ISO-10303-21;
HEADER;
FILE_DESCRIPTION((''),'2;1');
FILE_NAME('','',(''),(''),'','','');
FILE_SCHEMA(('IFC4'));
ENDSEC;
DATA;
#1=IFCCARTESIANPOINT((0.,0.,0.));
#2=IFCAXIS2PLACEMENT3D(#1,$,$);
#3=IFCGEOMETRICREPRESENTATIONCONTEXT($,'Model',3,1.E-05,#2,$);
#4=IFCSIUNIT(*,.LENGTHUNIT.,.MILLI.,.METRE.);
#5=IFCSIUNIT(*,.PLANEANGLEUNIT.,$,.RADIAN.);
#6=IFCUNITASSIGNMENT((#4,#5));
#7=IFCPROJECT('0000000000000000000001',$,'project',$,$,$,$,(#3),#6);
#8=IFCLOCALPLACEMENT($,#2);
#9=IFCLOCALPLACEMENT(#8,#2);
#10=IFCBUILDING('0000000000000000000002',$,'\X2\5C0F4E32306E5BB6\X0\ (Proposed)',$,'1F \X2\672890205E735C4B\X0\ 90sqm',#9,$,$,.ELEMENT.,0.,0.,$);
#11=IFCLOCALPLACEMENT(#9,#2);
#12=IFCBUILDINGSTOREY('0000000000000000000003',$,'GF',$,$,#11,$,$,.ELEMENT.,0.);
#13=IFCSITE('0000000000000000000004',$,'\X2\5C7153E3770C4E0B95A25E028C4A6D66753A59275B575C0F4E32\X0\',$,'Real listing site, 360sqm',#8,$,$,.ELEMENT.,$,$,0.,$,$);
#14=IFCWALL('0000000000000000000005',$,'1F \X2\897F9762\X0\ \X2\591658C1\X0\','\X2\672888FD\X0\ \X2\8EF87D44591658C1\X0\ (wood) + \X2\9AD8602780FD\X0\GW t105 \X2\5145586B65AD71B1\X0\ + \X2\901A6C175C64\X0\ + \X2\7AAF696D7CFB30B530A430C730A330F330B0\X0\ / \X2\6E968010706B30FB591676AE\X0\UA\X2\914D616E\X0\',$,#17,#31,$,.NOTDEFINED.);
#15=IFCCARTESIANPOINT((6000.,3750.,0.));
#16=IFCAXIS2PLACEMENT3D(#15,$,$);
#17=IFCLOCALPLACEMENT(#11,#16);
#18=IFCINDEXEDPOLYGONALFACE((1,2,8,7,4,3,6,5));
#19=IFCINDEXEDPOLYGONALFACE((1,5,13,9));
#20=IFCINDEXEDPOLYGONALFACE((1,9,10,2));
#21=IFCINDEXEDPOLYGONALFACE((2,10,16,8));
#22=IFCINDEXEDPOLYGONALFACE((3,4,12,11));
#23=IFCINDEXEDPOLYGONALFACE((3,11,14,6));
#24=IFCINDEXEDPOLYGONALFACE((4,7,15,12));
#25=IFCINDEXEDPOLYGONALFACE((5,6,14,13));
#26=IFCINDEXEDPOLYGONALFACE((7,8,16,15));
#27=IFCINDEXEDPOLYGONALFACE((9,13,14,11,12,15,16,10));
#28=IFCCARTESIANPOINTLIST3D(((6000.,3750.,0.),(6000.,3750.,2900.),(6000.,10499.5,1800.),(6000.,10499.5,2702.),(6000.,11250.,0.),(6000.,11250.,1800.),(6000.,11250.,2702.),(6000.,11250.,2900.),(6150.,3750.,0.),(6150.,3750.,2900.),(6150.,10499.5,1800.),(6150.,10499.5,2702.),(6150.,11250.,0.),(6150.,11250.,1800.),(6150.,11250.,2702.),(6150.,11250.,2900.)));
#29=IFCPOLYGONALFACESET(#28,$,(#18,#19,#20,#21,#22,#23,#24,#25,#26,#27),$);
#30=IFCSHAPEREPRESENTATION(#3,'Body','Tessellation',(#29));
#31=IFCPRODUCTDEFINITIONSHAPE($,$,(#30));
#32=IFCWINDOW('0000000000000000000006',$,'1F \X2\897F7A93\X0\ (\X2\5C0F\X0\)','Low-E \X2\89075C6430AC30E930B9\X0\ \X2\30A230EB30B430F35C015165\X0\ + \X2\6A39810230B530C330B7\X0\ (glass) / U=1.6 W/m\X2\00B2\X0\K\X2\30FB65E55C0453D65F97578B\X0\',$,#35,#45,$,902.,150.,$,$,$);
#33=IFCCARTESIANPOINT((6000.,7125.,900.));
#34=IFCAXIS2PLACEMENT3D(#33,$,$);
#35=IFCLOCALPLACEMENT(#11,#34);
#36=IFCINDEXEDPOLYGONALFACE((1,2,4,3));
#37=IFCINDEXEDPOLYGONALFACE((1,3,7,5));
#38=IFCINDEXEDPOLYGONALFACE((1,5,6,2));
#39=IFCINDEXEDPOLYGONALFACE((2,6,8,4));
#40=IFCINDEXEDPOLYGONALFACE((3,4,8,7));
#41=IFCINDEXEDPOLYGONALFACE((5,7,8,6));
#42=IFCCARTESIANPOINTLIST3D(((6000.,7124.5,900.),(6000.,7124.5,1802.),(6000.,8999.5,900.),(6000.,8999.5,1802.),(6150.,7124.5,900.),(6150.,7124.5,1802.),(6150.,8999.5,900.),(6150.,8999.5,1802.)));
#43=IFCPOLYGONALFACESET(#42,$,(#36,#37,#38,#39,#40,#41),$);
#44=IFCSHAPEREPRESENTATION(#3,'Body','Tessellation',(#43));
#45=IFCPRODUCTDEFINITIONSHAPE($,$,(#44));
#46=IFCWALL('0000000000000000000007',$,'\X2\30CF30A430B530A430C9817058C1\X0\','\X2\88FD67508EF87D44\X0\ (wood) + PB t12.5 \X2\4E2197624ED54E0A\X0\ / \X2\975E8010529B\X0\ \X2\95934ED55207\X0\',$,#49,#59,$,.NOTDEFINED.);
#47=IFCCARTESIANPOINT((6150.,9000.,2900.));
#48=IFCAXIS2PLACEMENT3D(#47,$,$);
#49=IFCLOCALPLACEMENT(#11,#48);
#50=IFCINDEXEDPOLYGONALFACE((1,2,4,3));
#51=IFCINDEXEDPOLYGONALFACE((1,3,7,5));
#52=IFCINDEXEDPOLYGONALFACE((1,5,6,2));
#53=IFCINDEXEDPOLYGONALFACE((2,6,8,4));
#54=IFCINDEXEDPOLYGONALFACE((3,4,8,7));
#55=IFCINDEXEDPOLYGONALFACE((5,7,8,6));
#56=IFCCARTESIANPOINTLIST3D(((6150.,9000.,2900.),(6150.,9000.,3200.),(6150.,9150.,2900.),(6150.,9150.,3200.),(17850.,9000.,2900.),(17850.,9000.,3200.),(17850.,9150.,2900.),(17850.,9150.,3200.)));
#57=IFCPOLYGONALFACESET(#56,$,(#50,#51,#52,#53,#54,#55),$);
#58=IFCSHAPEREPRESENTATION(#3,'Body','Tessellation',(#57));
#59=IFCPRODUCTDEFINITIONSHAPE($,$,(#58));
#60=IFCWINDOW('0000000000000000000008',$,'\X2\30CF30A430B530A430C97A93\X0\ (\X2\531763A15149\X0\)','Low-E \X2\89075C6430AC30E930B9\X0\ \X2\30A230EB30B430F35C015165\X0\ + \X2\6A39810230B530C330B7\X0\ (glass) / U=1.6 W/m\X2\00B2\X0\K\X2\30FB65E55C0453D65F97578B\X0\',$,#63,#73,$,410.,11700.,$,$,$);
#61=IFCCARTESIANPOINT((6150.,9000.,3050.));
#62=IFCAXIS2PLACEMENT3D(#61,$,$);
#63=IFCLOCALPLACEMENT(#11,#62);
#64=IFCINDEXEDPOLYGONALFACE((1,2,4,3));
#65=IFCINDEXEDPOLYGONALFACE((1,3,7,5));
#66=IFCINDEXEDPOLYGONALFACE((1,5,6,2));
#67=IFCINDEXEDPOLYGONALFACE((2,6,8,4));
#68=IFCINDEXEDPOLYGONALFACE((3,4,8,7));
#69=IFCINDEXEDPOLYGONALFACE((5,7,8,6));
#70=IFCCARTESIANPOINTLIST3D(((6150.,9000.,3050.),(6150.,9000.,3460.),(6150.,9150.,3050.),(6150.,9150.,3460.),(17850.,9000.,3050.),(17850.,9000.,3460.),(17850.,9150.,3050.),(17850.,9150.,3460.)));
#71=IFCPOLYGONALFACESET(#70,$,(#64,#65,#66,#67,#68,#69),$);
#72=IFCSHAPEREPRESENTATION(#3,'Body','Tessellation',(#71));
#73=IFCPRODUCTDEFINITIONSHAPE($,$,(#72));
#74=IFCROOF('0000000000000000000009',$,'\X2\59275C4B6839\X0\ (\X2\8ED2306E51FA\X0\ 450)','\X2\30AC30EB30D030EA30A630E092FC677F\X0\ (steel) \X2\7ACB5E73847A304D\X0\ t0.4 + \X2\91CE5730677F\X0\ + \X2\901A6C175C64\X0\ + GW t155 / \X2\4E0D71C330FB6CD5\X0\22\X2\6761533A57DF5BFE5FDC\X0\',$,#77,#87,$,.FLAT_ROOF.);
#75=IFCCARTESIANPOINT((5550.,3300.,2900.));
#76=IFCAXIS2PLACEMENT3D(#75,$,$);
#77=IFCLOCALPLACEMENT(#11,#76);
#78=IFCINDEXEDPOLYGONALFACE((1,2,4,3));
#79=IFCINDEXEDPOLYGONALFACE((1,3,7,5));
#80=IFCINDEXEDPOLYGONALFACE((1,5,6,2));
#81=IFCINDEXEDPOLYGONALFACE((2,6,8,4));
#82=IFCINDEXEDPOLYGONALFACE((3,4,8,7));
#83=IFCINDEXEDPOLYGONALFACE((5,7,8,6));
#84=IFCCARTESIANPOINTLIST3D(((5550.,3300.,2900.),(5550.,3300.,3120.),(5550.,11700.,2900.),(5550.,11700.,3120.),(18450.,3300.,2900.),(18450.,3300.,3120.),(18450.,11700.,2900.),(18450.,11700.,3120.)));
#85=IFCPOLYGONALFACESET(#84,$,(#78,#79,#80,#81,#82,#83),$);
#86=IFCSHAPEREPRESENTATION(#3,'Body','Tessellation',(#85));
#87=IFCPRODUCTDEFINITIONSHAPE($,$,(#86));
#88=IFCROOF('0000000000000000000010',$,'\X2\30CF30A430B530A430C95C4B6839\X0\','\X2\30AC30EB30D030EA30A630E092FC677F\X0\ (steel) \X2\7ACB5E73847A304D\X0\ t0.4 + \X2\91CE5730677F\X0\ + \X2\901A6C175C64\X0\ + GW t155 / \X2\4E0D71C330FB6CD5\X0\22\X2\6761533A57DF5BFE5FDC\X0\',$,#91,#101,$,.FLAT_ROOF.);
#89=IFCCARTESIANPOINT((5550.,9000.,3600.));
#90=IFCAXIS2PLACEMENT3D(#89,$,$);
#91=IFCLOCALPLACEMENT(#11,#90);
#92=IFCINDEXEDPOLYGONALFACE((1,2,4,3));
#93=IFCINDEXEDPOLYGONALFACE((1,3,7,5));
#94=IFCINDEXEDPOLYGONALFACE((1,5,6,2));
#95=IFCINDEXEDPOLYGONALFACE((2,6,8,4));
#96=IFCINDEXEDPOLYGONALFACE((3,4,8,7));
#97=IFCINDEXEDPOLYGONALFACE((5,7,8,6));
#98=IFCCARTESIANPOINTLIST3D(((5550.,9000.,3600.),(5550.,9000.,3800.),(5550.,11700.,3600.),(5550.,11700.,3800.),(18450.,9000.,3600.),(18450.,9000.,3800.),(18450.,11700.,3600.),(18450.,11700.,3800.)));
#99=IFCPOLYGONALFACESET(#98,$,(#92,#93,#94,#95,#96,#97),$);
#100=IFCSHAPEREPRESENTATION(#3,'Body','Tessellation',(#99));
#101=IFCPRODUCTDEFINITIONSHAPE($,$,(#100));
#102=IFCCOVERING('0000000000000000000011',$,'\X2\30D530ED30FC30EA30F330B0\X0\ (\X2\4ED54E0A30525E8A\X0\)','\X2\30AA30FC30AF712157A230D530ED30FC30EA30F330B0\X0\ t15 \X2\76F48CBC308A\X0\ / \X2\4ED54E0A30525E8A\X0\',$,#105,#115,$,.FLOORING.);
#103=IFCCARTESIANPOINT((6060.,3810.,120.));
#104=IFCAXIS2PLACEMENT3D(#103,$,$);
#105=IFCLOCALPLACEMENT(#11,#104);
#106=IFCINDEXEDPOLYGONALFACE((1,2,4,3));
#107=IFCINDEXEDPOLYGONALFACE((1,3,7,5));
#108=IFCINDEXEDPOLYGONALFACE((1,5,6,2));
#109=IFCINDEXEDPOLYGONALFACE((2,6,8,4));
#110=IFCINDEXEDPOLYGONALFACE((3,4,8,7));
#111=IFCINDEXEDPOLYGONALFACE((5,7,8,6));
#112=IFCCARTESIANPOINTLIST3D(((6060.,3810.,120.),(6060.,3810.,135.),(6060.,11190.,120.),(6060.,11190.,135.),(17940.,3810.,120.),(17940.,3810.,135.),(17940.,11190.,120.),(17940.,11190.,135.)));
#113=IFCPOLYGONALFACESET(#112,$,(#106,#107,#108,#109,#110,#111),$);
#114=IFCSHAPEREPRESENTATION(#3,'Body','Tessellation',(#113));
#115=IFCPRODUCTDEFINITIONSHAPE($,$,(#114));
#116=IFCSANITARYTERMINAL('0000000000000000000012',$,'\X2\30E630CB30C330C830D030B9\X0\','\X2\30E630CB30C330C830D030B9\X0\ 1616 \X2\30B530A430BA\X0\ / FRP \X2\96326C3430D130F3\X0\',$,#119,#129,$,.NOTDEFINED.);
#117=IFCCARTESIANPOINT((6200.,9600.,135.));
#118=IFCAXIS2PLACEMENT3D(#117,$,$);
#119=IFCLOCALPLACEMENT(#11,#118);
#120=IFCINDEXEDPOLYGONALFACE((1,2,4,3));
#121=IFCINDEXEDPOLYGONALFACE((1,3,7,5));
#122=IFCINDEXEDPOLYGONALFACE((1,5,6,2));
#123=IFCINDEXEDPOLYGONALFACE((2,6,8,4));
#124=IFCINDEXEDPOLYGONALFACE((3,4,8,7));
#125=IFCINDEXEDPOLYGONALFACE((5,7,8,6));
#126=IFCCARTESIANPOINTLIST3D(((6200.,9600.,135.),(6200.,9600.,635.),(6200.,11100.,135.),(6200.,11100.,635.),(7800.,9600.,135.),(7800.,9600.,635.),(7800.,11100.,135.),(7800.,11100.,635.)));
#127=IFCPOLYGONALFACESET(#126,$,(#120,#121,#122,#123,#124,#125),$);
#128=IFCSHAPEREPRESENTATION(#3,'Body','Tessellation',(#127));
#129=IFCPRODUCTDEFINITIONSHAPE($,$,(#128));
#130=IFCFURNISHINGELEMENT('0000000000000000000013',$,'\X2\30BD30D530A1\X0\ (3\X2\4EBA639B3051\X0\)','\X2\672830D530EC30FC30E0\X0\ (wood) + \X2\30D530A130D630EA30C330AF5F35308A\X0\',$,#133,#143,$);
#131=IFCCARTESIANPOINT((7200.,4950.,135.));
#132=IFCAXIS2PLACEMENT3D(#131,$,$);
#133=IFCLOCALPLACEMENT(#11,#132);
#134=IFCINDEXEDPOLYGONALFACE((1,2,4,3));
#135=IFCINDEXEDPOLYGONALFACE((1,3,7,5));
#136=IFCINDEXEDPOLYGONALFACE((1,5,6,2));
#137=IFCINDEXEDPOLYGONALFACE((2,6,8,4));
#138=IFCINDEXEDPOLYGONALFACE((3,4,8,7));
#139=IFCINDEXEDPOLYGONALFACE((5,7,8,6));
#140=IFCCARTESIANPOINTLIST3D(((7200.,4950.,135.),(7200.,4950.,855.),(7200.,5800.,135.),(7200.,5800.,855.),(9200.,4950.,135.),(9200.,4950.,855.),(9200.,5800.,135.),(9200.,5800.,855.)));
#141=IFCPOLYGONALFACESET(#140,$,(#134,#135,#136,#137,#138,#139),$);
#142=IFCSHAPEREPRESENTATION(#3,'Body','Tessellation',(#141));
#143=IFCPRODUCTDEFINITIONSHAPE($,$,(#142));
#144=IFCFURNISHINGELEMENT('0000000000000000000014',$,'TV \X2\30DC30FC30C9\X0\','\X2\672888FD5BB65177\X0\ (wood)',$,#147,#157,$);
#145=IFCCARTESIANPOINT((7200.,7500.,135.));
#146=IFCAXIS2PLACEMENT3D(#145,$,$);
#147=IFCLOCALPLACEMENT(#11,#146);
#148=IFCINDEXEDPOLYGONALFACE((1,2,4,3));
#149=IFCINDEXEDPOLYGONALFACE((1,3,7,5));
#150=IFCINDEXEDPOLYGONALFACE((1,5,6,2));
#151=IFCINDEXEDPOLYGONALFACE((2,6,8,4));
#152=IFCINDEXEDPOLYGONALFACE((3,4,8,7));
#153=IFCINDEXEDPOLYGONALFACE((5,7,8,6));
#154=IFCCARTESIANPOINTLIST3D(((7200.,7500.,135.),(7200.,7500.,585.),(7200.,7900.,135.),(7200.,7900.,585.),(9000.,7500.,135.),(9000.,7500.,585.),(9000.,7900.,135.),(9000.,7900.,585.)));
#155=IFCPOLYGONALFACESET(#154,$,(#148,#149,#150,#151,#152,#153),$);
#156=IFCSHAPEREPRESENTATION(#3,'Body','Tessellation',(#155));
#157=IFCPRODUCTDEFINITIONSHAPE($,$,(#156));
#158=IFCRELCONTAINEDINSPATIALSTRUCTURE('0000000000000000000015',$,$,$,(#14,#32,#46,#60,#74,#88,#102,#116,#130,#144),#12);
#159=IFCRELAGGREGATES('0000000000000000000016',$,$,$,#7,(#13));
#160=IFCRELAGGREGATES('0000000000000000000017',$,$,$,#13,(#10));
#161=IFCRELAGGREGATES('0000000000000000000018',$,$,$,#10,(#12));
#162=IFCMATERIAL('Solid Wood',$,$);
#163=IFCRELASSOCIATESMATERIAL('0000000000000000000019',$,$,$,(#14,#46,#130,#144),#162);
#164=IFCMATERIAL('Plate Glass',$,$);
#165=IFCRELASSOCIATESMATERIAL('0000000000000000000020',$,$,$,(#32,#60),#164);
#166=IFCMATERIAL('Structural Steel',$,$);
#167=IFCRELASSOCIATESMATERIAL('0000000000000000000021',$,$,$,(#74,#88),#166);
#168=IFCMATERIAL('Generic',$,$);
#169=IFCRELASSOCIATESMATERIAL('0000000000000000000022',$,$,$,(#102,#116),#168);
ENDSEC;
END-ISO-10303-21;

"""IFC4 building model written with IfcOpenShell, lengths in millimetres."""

from ifc_helpers import new_model, si_unit, frame, frame_2d, origin, place, context, project, spatial, rectangle, extrude, material, element, fill, save


model = new_model("IFC4")

# Units and contexts
model_context = context("Model", 3, precision=1e-05, world=origin())
ifc_project = project(units=[si_unit("LENGTHUNIT", "METRE", prefix="MILLI"), si_unit("PLANEANGLEUNIT", "RADIAN")], contexts=[model_context])

# Site, building, storey
site_placement = place(None, origin())
site = spatial("IfcSite", under=ifc_project, at=site_placement, Name="山口県下関市豊浦町大字小串", ObjectType="Real listing site, 360sqm", CompositionType="ELEMENT", RefElevation=0.0)
building_placement = place(site_placement, origin())
building = spatial("IfcBuilding", under=site, at=building_placement, Name="小串の家 (Proposed)", ObjectType="1F 木造平屋 90sqm", CompositionType="ELEMENT", ElevationOfRefHeight=0.0, ElevationOfTerrain=0.0)
storey_placement = place(building_placement, origin())
storey = spatial("IfcBuildingStorey", under=building, at=storey_placement, Name="GF", CompositionType="ELEMENT", Elevation=0.0)

# Shared definitions
ifc_material_1 = material(Name="Solid Wood")

# Shared definitions
ifc_material_2 = material(Name="Plate Glass")

# Wall, opening, window
wall_1_placement = place(storey_placement, frame((6000.0, 3750.0, 0.0)))
wall_1 = element("IfcWall", 1, at=wall_1_placement, inside=storey, material=ifc_material_1, Name="1F 西面 外壁", Description="木製 軸組外壁 (wood) + 高性能GW t105 充填断熱 + 通気層 + 窯業系サイディング / 準耐火・外皮UA配慮", PredefinedType="NOTDEFINED", context=model_context, shape_type="SweptSolid", body=[
    extrude(rectangle(XDim=150.0, YDim=7500.0, at=frame_2d((75.0, 3750.0))), frame((6000.0, 3750.0, 0.0)), (0.0, 0.0, 1.0), 2900.0),
])
opening_1_placement = place(storey_placement, frame((6000.0, 7125.0, 900.0)))
opening_1 = element("IfcOpeningElement", 2, at=opening_1_placement, cuts=wall_1, PredefinedType="NOTDEFINED", context=model_context, shape_type="SweptSolid", body=[
    extrude(rectangle(XDim=150.0, YDim=1875.0, at=frame_2d((75.0, 937.0))), frame((6000.0, 7125.0, 900.0)), (0.0, 0.0, 1.0), 902.0),
])
window_1_placement = place(storey_placement, frame((6000.0, 7125.0, 900.0)))
window_1 = element("IfcWindow", 3, at=window_1_placement, inside=storey, material=ifc_material_2, Name="1F 西窓 (小)", Description="Low-E 複層ガラス アルゴン封入 + 樹脂サッシ (glass) / U=1.6 W/m²K・日射取得型", OverallHeight=902.0, OverallWidth=150.0, context=model_context, shape_type="SweptSolid", body=[
    extrude(rectangle(XDim=150.0, YDim=1875.0, at=frame_2d((75.0, 937.0))), frame((6000.0, 7125.0, 900.0)), (0.0, 0.0, 1.0), 902.0),
])
fill(opening_1, window_1)

# Wall, opening, window
wall_2_placement = place(storey_placement, frame((6150.0, 9000.0, 2900.0)))
wall_2 = element("IfcWall", 4, at=wall_2_placement, inside=storey, material=ifc_material_1, Name="ハイサイド腰壁", Description="製材軸組 (wood) + PB t12.5 両面仕上 / 非耐力 間仕切", PredefinedType="NOTDEFINED", context=model_context, shape_type="SweptSolid", body=[
    extrude(rectangle(XDim=11700.0, YDim=150.0, at=frame_2d((5850.0, 75.0))), frame((6150.0, 9000.0, 2900.0)), (0.0, 0.0, 1.0), 700.0),
])
opening_2_placement = place(storey_placement, frame((6150.0, 9000.0, 3050.0)))
opening_2 = element("IfcOpeningElement", 5, at=opening_2_placement, cuts=wall_2, PredefinedType="NOTDEFINED", context=model_context, shape_type="SweptSolid", body=[
    extrude(rectangle(XDim=11700.0, YDim=150.0, at=frame_2d((5850.0, 75.0))), frame((6150.0, 9000.0, 3050.0)), (0.0, 0.0, 1.0), 410.0),
])
window_2_placement = place(storey_placement, frame((6150.0, 9000.0, 3050.0)))
window_2 = element("IfcWindow", 6, at=window_2_placement, inside=storey, material=ifc_material_2, Name="ハイサイド窓 (北採光)", Description="Low-E 複層ガラス アルゴン封入 + 樹脂サッシ (glass) / U=1.6 W/m²K・日射取得型", OverallHeight=410.0, OverallWidth=11700.0, context=model_context, shape_type="SweptSolid", body=[
    extrude(rectangle(XDim=11700.0, YDim=150.0, at=frame_2d((5850.0, 75.0))), frame((6150.0, 9000.0, 3050.0)), (0.0, 0.0, 1.0), 410.0),
])
fill(opening_2, window_2)

# Roofs
ifc_material_3 = material(Name="Structural Steel")
roof_1_placement = place(storey_placement, frame((5550.0, 3300.0, 2900.0)))
element("IfcRoof", 7, at=roof_1_placement, inside=storey, material=ifc_material_3, Name="大屋根 (軒の出 450)", Description="ガルバリウム鋼板 (steel) 立平葺き t0.4 + 野地板 + 通気層 + GW t155 / 不燃・法22条区域対応", PredefinedType="FLAT_ROOF", context=model_context, shape_type="SweptSolid", body=[
    extrude(rectangle(XDim=12900.0, YDim=8400.0, at=frame_2d((6450.0, 4200.0))), frame((5550.0, 3300.0, 2900.0)), (0.0, 0.0, 1.0), 220.0),
])
roof_2_placement = place(storey_placement, frame((5550.0, 9000.0, 3600.0)))
element("IfcRoof", 8, at=roof_2_placement, inside=storey, material=ifc_material_3, Name="ハイサイド屋根", Description="ガルバリウム鋼板 (steel) 立平葺き t0.4 + 野地板 + 通気層 + GW t155 / 不燃・法22条区域対応", PredefinedType="FLAT_ROOF", context=model_context, shape_type="SweptSolid", body=[
    extrude(rectangle(XDim=12900.0, YDim=2700.0, at=frame_2d((6450.0, 1350.0))), frame((5550.0, 9000.0, 3600.0)), (0.0, 0.0, 1.0), 200.0),
])

# Covering
ifc_material_4 = material(Name="Generic")
covering_placement = place(storey_placement, frame((6060.0, 3810.0, 120.0)))
element("IfcCovering", 9, at=covering_placement, inside=storey, material=ifc_material_4, Name="フローリング (仕上げ床)", Description="オーク無垢フローリング t15 直貼り / 仕上げ床", PredefinedType="FLOORING", context=model_context, shape_type="SweptSolid", body=[
    extrude(rectangle(XDim=11880.0, YDim=7380.0, at=frame_2d((5940.0, 3690.0))), frame((6060.0, 3810.0, 120.0)), (0.0, 0.0, 1.0), 15.0),
])

# Sanitary terminal
sanitary_terminal_placement = place(storey_placement, frame((6200.0, 9600.0, 135.0)))
element("IfcSanitaryTerminal", 10, at=sanitary_terminal_placement, inside=storey, material=ifc_material_4, Name="ユニットバス", Description="ユニットバス 1616 サイズ / FRP 防水パン", PredefinedType="NOTDEFINED", context=model_context, shape_type="SweptSolid", body=[
    extrude(rectangle(XDim=1600.0, YDim=1500.0, at=frame_2d((800.0, 750.0))), frame((6200.0, 9600.0, 135.0)), (0.0, 0.0, 1.0), 500.0),
])

# Furnishing elements
furnishing_1_placement = place(storey_placement, frame((7200.0, 4950.0, 135.0)))
element("IfcFurnishingElement", 11, at=furnishing_1_placement, inside=storey, material=ifc_material_1, Name="ソファ (3人掛け)", Description="木フレーム (wood) + ファブリック張り", context=model_context, shape_type="SweptSolid", body=[
    extrude(rectangle(XDim=2000.0, YDim=850.0, at=frame_2d((1000.0, 425.0))), frame((7200.0, 4950.0, 135.0)), (0.0, 0.0, 1.0), 720.0),
])
furnishing_2_placement = place(storey_placement, frame((7200.0, 7500.0, 135.0)))
element("IfcFurnishingElement", 12, at=furnishing_2_placement, inside=storey, material=ifc_material_1, Name="TV ボード", Description="木製家具 (wood)", context=model_context, shape_type="SweptSolid", body=[
    extrude(rectangle(XDim=1800.0, YDim=400.0, at=frame_2d((900.0, 200.0))), frame((7200.0, 7500.0, 135.0)), (0.0, 0.0, 1.0), 450.0),
])

save(model, "model.ifc")
